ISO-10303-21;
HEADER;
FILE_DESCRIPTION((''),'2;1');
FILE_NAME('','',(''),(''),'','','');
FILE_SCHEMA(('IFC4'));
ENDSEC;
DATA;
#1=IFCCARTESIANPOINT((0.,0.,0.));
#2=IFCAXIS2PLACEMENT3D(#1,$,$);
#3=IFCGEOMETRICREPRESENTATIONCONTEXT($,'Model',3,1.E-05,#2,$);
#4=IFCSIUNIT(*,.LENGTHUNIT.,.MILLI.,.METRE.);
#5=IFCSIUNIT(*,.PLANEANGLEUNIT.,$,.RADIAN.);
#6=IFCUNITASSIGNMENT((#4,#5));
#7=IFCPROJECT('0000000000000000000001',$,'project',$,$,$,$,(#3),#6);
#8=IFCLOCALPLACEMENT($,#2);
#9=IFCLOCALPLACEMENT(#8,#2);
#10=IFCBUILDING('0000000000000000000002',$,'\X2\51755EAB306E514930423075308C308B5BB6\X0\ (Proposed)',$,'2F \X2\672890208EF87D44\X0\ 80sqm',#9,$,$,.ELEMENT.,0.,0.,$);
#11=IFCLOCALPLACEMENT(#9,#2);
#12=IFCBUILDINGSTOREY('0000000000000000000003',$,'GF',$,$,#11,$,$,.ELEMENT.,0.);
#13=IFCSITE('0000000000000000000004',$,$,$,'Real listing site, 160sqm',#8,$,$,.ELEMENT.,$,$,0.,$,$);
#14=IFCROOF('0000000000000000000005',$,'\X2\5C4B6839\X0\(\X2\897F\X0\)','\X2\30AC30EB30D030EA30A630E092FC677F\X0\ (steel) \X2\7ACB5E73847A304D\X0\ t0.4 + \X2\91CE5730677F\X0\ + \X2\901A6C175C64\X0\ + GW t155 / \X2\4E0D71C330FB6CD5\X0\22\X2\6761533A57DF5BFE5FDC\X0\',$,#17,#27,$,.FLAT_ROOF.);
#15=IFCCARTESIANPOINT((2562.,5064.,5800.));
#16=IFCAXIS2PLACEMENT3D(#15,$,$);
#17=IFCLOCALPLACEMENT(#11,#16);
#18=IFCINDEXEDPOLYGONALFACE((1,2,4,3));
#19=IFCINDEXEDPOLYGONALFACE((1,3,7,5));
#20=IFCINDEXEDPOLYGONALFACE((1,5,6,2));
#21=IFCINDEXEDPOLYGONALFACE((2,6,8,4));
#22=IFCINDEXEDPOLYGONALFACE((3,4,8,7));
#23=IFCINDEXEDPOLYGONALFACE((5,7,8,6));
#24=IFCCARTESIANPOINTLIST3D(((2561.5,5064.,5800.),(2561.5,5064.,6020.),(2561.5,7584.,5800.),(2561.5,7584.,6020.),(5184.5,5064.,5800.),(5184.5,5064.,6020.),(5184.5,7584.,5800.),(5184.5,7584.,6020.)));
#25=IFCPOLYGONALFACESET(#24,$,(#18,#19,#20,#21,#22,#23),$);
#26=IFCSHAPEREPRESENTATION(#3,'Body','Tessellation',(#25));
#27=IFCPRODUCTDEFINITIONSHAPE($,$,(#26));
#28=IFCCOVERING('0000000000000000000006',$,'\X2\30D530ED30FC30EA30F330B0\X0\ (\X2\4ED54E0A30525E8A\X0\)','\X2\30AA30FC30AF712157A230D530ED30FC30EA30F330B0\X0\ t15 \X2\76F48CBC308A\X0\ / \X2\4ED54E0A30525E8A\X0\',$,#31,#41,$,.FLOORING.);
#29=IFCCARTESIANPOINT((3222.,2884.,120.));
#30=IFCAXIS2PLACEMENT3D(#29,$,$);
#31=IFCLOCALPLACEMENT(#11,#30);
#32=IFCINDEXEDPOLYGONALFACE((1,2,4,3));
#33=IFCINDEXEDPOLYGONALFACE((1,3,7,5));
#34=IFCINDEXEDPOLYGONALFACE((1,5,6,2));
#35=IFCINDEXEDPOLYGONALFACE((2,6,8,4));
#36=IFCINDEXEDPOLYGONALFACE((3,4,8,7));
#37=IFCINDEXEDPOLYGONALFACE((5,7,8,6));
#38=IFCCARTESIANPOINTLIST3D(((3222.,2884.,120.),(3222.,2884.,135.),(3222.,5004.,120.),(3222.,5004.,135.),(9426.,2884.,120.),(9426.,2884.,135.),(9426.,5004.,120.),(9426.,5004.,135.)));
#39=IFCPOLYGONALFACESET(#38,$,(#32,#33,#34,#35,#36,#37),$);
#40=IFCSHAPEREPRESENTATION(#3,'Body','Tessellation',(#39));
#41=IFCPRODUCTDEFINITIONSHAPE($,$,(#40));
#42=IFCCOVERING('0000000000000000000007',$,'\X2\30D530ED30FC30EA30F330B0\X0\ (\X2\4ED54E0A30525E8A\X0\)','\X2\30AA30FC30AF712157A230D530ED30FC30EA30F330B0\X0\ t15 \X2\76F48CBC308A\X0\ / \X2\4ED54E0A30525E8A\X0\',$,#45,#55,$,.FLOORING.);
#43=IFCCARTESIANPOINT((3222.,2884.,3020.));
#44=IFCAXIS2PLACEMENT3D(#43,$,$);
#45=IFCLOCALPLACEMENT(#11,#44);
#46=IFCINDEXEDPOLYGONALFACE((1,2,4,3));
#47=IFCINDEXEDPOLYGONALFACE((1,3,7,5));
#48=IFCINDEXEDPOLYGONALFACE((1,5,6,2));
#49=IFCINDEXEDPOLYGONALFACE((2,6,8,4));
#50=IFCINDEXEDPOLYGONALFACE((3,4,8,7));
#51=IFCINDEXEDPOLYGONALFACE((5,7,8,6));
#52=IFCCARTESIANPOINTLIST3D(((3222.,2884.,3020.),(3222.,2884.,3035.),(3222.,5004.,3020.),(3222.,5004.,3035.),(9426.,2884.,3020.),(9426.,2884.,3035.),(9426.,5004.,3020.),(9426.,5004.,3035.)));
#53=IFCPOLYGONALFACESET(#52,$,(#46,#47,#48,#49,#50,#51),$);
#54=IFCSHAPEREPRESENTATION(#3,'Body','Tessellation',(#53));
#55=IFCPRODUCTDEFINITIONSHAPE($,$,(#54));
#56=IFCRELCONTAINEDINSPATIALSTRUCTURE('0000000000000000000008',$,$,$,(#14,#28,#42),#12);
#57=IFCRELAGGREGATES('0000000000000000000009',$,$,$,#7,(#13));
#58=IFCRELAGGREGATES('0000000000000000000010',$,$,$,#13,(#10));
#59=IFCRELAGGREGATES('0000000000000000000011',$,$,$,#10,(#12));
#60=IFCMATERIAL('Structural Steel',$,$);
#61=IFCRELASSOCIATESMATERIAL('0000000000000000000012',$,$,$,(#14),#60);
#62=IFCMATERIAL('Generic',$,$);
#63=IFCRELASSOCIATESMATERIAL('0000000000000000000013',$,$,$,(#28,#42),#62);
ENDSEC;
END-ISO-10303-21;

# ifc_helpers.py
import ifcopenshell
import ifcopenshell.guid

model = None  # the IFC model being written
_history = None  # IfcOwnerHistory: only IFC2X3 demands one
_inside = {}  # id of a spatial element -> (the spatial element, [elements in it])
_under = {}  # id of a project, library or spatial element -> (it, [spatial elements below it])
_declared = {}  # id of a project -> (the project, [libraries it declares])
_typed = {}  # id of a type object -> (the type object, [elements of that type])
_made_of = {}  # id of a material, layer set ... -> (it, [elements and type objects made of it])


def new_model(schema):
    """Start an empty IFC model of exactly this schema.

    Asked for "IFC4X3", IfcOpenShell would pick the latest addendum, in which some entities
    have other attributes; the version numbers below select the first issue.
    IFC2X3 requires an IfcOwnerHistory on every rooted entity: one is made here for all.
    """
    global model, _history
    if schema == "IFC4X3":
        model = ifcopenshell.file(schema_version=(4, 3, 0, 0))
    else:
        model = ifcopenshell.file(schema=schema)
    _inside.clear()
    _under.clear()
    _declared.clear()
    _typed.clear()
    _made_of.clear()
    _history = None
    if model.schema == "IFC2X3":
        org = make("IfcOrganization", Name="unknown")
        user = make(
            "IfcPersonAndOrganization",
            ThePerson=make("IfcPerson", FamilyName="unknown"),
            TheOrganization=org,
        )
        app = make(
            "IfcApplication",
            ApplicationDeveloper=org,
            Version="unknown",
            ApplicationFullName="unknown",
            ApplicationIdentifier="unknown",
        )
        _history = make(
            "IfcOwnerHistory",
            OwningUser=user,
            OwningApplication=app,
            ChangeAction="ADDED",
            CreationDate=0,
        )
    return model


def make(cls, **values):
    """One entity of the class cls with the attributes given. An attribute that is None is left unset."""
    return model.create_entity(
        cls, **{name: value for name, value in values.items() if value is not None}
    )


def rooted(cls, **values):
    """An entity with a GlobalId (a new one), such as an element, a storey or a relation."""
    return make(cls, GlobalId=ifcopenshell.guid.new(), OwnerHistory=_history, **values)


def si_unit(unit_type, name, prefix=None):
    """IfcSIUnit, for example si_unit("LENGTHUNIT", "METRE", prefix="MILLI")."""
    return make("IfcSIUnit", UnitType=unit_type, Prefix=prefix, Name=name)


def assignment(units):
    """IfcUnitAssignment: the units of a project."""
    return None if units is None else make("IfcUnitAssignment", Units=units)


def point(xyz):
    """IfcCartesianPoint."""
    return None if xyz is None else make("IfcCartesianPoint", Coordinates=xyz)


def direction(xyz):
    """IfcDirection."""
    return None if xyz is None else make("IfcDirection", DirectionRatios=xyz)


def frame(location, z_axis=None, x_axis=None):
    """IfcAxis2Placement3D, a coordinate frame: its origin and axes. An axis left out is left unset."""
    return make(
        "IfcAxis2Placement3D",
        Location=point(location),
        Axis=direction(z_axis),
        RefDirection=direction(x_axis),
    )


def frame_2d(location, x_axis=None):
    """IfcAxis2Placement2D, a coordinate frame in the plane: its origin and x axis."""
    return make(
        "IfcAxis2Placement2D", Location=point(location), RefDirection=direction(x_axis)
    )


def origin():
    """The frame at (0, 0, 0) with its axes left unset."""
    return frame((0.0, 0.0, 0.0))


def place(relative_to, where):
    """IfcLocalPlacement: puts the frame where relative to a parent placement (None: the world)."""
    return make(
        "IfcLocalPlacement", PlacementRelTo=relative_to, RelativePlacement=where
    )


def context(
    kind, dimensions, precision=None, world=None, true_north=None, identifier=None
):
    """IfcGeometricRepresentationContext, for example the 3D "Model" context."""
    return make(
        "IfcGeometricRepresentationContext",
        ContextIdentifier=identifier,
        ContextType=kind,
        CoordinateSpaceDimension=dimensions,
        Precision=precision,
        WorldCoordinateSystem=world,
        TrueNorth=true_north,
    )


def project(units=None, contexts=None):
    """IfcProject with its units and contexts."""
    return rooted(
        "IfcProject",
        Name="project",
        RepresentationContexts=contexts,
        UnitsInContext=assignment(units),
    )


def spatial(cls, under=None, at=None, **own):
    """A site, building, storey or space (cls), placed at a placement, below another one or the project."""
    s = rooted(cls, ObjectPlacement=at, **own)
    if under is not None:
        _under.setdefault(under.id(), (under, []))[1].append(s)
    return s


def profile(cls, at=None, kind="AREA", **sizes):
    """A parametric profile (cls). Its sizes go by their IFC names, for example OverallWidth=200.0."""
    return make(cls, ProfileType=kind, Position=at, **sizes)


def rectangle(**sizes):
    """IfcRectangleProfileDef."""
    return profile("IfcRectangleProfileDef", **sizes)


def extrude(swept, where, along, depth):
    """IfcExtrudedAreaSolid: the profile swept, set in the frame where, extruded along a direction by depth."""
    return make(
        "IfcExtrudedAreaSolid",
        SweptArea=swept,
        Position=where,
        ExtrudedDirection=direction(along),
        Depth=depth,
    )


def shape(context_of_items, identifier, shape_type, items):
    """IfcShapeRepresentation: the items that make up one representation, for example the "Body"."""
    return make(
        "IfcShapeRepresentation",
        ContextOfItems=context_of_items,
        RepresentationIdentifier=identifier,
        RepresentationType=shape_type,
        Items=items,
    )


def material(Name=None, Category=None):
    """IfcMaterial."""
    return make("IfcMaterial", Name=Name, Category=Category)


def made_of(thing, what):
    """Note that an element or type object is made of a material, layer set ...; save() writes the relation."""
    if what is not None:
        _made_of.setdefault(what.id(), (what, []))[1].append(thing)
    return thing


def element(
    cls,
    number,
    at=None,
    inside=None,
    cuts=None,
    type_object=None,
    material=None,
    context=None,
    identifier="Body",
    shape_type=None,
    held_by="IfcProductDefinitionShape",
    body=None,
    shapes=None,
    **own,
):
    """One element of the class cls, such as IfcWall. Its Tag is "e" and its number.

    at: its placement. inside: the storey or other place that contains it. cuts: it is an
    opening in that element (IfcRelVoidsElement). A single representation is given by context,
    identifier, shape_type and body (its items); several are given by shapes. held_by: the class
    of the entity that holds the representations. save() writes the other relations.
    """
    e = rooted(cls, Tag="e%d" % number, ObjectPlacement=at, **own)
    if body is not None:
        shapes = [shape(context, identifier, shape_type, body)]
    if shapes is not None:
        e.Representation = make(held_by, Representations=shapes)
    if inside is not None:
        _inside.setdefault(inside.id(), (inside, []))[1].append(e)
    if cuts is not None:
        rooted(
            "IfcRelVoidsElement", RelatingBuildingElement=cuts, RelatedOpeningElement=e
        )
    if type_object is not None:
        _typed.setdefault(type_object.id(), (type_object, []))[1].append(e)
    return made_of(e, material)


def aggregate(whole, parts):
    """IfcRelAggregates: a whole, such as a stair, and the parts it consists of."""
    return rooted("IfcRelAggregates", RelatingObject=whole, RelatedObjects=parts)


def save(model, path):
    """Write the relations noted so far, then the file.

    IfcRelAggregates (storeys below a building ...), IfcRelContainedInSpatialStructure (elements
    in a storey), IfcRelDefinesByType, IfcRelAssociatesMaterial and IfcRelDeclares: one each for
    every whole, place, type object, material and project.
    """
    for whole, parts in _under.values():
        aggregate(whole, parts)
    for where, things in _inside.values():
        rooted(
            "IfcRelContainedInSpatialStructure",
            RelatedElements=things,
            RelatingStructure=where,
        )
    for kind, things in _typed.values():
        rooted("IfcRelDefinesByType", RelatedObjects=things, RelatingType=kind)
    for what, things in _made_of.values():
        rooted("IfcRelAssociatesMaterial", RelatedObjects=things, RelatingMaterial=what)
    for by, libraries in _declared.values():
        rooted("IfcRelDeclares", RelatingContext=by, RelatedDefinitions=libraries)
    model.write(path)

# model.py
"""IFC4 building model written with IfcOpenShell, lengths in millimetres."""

from ifc_helpers import new_model, si_unit, frame, frame_2d, origin, place, context, project, spatial, rectangle, extrude, material, element, save


model = new_model("IFC4")

# Units and contexts
model_context = context("Model", 3, precision=1e-05, world=origin())
ifc_project = project(units=[si_unit("LENGTHUNIT", "METRE", prefix="MILLI"), si_unit("PLANEANGLEUNIT", "RADIAN")], contexts=[model_context])

# Site, building, storey
site_placement = place(None, origin())
site = spatial("IfcSite", under=ifc_project, at=site_placement, ObjectType="Real listing site, 160sqm", CompositionType="ELEMENT", RefElevation=0.0)
building_placement = place(site_placement, origin())
building = spatial("IfcBuilding", under=site, at=building_placement, Name="兵庫の光あふれる家 (Proposed)", ObjectType="2F 木造軸組 80sqm", CompositionType="ELEMENT", ElevationOfRefHeight=0.0, ElevationOfTerrain=0.0)
storey_placement = place(building_placement, origin())
storey = spatial("IfcBuildingStorey", under=building, at=storey_placement, Name="GF", CompositionType="ELEMENT", Elevation=0.0)

# Roof
ifc_material_1 = material(Name="Structural Steel")
roof_1_placement = place(storey_placement, frame((2562.0, 5064.0, 5800.0)))
element("IfcRoof", 1, at=roof_1_placement, inside=storey, material=ifc_material_1, Name="屋根(西)", Description="ガルバリウム鋼板 (steel) 立平葺き t0.4 + 野地板 + 通気層 + GW t155 / 不燃・法22条区域対応", PredefinedType="FLAT_ROOF", context=model_context, shape_type="SweptSolid", body=[
    extrude(rectangle(XDim=2623.0, YDim=2520.0, at=frame_2d((1311.0, 1260.0))), frame((2562.0, 5064.0, 5800.0)), (0.0, 0.0, 1.0), 220.0),
])

# Coverings
ifc_material_2 = material(Name="Generic")
covering_1_placement = place(storey_placement, frame((3222.0, 2884.0, 120.0)))
element("IfcCovering", 2, at=covering_1_placement, inside=storey, material=ifc_material_2, Name="フローリング (仕上げ床)", Description="オーク無垢フローリング t15 直貼り / 仕上げ床", PredefinedType="FLOORING", context=model_context, shape_type="SweptSolid", body=[
    extrude(rectangle(XDim=6204.0, YDim=2120.0, at=frame_2d((3102.0, 1060.0))), frame((3222.0, 2884.0, 120.0)), (0.0, 0.0, 1.0), 15.0),
])
covering_2_placement = place(storey_placement, frame((3222.0, 2884.0, 3020.0)))
element("IfcCovering", 3, at=covering_2_placement, inside=storey, material=ifc_material_2, Name="フローリング (仕上げ床)", Description="オーク無垢フローリング t15 直貼り / 仕上げ床", PredefinedType="FLOORING", context=model_context, shape_type="SweptSolid", body=[
    extrude(rectangle(XDim=6204.0, YDim=2120.0, at=frame_2d((3102.0, 1060.0))), frame((3222.0, 2884.0, 3020.0)), (0.0, 0.0, 1.0), 15.0),
])

save(model, "model.ifc")
